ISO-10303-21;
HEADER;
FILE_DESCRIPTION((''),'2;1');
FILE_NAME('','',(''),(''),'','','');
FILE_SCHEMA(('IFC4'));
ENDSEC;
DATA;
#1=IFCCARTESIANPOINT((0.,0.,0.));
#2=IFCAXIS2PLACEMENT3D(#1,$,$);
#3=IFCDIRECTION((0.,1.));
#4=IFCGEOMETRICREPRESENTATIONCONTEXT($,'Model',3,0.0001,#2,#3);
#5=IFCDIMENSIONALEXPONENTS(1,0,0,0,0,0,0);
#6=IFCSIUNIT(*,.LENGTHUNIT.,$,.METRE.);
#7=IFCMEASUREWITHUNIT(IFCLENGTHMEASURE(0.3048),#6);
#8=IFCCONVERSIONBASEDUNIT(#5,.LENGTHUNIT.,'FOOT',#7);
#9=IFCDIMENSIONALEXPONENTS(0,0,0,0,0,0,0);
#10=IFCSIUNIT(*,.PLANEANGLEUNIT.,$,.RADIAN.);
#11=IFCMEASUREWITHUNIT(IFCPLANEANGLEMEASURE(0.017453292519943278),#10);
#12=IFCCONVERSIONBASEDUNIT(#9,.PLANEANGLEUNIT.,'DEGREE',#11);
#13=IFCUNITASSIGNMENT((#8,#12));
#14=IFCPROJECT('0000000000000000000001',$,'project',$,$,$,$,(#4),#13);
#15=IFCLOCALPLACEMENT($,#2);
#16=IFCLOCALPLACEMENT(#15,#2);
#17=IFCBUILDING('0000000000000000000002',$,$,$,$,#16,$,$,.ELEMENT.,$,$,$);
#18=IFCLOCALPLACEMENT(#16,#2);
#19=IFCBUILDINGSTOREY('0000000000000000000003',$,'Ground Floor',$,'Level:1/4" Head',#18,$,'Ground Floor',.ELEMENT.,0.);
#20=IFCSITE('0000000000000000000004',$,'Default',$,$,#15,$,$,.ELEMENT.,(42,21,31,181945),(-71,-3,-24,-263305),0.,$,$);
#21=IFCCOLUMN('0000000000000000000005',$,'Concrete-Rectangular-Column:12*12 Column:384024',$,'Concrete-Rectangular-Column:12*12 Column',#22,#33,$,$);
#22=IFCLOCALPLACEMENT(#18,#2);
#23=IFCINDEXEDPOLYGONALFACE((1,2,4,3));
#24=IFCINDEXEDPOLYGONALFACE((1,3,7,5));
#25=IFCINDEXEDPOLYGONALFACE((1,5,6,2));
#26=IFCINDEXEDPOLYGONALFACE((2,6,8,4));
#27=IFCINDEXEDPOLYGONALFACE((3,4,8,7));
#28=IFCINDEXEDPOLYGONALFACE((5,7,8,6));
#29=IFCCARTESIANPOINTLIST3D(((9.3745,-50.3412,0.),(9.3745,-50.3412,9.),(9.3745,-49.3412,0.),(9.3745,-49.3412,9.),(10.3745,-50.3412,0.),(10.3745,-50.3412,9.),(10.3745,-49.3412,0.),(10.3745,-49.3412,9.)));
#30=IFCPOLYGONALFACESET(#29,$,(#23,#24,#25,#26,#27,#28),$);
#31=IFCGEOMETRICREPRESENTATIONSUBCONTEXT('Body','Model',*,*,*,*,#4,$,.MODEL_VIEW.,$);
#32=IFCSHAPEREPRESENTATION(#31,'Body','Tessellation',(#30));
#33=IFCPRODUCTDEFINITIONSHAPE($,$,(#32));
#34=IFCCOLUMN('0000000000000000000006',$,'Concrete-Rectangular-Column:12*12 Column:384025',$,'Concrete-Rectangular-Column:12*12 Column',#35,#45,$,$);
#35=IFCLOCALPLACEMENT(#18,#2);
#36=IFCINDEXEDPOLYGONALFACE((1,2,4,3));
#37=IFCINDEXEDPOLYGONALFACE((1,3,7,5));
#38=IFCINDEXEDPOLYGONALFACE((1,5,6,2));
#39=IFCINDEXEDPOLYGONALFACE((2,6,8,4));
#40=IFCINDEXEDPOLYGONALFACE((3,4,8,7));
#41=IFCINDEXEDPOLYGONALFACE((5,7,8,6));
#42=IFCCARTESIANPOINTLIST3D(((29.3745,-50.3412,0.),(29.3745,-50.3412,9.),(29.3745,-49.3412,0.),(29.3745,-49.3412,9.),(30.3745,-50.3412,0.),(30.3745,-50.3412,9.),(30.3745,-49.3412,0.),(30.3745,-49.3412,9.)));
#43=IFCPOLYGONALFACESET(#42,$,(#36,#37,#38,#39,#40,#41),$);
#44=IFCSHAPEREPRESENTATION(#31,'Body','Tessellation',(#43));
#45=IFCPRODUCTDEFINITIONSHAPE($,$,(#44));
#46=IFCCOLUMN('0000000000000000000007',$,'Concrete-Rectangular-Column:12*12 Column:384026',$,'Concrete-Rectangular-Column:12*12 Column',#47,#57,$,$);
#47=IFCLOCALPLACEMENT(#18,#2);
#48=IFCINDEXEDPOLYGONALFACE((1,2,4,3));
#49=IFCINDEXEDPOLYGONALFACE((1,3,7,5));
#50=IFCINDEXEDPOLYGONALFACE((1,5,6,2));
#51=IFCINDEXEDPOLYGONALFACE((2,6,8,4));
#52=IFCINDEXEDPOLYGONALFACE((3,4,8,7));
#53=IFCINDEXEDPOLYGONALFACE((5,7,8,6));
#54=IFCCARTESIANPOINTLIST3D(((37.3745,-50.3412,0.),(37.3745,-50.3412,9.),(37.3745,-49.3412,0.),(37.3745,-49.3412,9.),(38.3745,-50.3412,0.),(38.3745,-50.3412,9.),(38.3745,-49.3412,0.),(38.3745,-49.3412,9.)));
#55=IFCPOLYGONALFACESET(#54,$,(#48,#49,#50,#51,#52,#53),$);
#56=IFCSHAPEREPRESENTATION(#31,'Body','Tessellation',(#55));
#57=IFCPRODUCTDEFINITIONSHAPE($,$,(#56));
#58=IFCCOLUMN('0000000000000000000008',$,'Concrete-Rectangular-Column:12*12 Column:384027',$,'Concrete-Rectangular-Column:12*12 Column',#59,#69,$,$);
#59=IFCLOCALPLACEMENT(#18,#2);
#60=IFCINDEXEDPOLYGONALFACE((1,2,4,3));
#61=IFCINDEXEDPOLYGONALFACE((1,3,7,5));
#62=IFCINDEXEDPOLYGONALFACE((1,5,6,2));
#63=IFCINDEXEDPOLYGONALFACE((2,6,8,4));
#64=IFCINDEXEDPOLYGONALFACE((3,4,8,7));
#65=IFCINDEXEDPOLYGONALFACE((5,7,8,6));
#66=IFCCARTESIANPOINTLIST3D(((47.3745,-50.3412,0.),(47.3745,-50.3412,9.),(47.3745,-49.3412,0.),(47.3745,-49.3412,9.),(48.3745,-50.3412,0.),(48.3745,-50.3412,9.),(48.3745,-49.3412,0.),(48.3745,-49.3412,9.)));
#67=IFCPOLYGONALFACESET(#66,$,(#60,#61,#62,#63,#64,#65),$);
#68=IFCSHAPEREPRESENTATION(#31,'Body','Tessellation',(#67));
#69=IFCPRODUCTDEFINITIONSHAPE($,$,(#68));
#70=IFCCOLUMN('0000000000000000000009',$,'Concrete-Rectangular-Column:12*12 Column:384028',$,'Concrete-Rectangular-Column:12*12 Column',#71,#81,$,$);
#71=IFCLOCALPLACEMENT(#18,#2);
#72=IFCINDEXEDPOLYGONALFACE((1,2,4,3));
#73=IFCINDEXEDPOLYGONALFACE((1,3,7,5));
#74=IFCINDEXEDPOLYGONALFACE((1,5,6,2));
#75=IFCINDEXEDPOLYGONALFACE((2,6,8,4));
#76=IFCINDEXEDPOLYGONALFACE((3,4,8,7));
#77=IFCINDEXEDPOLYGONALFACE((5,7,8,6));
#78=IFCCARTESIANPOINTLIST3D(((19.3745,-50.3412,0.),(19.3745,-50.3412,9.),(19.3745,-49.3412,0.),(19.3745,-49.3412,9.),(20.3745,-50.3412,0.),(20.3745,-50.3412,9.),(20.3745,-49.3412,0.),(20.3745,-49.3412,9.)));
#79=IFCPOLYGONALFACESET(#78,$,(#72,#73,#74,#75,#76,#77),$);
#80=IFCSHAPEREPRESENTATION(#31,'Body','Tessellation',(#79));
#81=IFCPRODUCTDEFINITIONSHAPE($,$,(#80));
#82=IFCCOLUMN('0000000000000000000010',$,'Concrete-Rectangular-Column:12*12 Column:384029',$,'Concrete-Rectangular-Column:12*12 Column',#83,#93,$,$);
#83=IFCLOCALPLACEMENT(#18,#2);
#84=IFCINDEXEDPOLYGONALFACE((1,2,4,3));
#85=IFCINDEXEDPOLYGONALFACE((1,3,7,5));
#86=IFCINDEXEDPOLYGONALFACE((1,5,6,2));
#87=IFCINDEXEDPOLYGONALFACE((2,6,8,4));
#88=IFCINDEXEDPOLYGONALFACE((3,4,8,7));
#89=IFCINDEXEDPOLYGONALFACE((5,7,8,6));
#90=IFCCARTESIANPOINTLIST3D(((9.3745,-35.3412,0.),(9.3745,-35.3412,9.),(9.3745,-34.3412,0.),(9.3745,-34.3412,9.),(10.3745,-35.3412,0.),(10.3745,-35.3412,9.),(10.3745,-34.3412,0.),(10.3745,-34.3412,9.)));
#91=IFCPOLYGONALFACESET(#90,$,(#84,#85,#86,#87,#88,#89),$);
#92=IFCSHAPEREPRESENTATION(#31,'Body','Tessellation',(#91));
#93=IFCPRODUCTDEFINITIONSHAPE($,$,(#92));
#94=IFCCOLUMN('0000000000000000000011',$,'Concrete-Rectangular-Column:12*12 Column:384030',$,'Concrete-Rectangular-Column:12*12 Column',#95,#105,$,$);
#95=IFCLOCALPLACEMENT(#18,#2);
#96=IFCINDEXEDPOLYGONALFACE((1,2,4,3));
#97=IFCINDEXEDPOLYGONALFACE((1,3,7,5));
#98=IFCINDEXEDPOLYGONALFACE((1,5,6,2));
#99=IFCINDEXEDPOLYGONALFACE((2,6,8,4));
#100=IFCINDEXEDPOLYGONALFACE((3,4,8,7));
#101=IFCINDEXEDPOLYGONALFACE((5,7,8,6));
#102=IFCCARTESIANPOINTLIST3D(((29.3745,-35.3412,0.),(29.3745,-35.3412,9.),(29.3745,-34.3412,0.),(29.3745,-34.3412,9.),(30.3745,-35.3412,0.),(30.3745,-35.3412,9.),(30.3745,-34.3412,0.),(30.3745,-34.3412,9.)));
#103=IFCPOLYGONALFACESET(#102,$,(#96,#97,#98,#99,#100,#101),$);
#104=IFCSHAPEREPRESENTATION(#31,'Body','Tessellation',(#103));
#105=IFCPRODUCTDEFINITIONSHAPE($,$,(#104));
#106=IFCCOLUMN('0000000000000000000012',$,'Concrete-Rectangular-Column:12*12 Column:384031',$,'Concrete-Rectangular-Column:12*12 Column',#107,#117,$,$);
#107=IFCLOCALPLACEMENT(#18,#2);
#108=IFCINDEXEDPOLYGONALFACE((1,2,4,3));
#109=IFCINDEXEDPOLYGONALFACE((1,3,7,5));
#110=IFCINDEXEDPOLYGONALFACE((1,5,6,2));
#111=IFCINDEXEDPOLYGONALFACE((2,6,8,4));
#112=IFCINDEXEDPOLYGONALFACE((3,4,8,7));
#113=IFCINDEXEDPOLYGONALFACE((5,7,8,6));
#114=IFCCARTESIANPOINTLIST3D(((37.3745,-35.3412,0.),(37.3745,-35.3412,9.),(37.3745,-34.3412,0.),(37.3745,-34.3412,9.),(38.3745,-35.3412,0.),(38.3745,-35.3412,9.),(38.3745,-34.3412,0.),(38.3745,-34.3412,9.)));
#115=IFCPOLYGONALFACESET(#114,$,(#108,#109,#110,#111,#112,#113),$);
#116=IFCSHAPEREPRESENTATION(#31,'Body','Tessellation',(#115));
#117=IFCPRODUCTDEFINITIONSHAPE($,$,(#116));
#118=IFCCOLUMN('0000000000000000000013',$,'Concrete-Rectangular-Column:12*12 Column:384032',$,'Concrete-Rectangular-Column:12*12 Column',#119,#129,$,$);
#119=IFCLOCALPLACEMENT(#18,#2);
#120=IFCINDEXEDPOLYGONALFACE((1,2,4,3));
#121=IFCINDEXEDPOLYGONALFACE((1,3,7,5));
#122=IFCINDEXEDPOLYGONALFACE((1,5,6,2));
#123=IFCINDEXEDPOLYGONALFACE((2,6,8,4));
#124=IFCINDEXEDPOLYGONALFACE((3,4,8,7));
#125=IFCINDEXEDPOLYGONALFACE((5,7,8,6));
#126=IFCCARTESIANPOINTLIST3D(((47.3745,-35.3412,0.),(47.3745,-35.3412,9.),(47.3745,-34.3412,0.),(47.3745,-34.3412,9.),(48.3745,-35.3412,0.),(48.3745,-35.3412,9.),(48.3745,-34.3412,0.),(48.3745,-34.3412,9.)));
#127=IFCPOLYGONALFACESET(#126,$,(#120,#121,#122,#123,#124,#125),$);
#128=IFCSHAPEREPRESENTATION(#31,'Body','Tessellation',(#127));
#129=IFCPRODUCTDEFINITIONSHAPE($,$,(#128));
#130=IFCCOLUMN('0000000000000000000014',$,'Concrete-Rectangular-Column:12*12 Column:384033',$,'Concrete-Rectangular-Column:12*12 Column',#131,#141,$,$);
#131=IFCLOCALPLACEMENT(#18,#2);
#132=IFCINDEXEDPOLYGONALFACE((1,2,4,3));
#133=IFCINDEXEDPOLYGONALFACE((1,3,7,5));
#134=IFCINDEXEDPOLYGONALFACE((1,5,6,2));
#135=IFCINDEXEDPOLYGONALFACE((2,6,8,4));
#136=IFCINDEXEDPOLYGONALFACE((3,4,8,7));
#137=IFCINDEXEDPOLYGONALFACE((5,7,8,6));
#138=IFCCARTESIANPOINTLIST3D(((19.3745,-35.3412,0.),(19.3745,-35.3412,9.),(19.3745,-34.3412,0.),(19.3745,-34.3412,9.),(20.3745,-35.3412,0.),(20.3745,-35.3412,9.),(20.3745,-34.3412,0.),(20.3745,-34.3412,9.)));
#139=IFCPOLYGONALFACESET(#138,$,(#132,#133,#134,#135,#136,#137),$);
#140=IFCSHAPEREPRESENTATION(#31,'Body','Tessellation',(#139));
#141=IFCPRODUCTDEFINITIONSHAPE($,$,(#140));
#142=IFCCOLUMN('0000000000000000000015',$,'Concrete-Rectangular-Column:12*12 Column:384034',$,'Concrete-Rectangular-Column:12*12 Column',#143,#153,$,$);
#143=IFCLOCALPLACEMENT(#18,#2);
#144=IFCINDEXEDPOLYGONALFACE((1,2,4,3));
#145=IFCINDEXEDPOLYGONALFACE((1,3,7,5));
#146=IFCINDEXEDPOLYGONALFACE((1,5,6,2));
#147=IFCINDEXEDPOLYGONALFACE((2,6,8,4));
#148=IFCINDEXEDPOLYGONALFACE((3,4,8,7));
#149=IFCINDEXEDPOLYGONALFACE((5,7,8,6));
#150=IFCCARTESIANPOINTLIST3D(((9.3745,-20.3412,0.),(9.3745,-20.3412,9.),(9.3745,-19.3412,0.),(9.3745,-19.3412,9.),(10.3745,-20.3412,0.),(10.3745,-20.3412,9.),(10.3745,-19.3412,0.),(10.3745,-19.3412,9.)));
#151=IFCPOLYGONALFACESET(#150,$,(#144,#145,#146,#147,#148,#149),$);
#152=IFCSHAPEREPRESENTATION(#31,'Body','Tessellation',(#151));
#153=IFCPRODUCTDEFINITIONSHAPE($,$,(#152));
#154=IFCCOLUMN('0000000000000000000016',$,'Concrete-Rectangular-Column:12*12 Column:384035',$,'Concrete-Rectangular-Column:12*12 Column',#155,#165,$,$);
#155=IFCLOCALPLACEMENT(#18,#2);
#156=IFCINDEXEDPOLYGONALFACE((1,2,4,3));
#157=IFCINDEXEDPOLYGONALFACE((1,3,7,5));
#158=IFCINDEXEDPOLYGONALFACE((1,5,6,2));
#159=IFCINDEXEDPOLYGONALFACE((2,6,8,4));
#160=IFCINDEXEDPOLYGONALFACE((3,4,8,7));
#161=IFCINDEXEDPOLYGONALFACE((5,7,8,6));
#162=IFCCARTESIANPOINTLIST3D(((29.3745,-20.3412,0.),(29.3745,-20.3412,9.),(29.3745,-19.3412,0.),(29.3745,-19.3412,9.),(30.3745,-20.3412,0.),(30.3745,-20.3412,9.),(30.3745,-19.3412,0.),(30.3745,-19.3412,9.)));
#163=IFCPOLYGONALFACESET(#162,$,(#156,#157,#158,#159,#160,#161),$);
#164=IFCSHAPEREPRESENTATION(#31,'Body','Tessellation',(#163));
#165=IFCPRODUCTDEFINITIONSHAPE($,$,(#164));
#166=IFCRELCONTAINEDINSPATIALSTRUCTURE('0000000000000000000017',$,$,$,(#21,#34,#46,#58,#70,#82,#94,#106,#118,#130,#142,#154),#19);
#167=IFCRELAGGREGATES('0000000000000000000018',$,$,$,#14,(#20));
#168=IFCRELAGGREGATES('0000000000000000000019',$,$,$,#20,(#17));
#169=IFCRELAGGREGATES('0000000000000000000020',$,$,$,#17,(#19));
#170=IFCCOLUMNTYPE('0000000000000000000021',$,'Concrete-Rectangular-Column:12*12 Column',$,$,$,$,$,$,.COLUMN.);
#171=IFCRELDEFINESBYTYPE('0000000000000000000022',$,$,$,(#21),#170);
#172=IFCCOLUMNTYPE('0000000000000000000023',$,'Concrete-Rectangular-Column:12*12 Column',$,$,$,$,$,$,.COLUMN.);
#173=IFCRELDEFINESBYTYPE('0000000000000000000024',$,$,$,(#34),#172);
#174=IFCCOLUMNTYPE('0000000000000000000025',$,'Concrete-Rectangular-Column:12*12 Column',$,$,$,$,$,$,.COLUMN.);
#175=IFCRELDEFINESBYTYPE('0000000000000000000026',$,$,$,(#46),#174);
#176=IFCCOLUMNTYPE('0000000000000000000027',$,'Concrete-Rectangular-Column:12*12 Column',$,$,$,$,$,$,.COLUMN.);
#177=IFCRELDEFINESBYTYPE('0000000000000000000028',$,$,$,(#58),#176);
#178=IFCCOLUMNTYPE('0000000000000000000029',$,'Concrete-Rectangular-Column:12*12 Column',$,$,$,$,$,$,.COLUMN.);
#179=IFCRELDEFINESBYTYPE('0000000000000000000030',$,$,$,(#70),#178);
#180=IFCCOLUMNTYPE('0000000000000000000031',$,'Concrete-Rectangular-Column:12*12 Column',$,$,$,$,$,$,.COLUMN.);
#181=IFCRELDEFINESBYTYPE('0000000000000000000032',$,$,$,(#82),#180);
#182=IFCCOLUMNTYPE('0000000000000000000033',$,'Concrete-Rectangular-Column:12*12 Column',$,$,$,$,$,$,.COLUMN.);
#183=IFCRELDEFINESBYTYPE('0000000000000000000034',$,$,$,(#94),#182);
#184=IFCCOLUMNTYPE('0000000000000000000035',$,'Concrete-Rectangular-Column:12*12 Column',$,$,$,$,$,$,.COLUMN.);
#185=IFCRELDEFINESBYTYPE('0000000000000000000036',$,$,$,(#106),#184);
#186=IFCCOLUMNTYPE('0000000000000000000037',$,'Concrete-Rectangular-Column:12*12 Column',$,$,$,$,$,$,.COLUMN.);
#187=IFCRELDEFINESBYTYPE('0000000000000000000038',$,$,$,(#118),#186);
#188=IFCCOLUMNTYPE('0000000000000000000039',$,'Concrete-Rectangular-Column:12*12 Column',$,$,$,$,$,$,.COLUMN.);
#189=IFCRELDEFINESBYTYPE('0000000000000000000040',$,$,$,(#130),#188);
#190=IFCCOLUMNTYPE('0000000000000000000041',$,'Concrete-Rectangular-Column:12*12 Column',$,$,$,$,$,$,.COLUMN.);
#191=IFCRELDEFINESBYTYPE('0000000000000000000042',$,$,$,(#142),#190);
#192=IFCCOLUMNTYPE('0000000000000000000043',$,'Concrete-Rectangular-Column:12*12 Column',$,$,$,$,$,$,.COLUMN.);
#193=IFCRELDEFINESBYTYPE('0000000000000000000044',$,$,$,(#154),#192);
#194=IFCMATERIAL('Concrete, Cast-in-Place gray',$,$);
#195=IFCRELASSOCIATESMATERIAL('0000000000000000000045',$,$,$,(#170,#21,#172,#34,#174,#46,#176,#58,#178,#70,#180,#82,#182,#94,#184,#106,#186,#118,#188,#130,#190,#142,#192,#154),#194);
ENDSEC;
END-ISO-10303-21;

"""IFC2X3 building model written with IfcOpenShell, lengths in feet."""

from ifc_helpers import new_model, entity, si_unit, converted_unit, direction, frame, frame_2d, origin, origin_2d_with_axis, place, context, subcontext, project, spatial, rectangle, extrude, source, transform, mapped, material, type_object, type_shapes, element, save


model = new_model("IFC2X3")

# Units and contexts
model_context = context("Model", 3, precision=0.0001, world=origin(), true_north=direction((0.0, 1.0)))
body_context = subcontext(model_context, "Body", "Model", "MODEL_VIEW")
ifc_project = project(units=[converted_unit("LENGTHUNIT", "FOOT", entity("IfcLengthMeasure", 0.3048), si_unit("LENGTHUNIT", "METRE"), dimensions=[1, 0, 0, 0, 0, 0, 0]), converted_unit("PLANEANGLEUNIT", "DEGREE", entity("IfcPlaneAngleMeasure", 0.017453292519943278), si_unit("PLANEANGLEUNIT", "RADIAN"), dimensions=[0, 0, 0, 0, 0, 0, 0])], contexts=[model_context])

# Site, building, storey
site_placement = place(None, origin())
site = spatial("IfcSite", under=ifc_project, at=site_placement, Name="Default", CompositionType="ELEMENT", RefLatitude=(42, 21, 31, 181945), RefLongitude=(-71, -3, -24, -263305), RefElevation=0.0)
building_placement = place(site_placement, origin())
building = spatial("IfcBuilding", under=site, at=building_placement, CompositionType="ELEMENT")
storey_placement = place(building_placement, origin())
storey = spatial("IfcBuildingStorey", under=building, at=storey_placement, Name="Ground Floor", ObjectType="Level:1/4\" Head", LongName="Ground Floor", CompositionType="ELEMENT", Elevation=0.0)

# Columns
ifc_material = material(Name="Concrete, Cast-in-Place gray")
column_type_1 = type_object("IfcColumnType", Name="Concrete-Rectangular-Column:12*12 Column", PredefinedType="COLUMN", material=ifc_material)
shared_shape_1 = source(origin(), body_context, "Body", "SweptSolid", [
    extrude(rectangle(XDim=1.0, YDim=1.0, at=origin_2d_with_axis()), frame((9.8745, -49.8412, 0.0), z_axis=(0.0, 0.0, 1.0), x_axis=(-1.0, 0.0, 0.0)), (0.0, 0.0, 1.0), 9.0),
])
type_shapes(column_type_1, [shared_shape_1])
column_1_placement = place(storey_placement, origin())
element("IfcColumn", 1, at=column_1_placement, inside=storey, type_object=column_type_1, material=ifc_material, Name="Concrete-Rectangular-Column:12*12 Column:384024", ObjectType="Concrete-Rectangular-Column:12*12 Column", context=body_context, shape_type="MappedRepresentation", body=[
    mapped(shared_shape_1, transform((0.0, 0.0, 0.0), scale=1.0)),
])
column_type_2 = type_object("IfcColumnType", Name="Concrete-Rectangular-Column:12*12 Column", PredefinedType="COLUMN", material=ifc_material)
shared_shape_2 = source(origin(), body_context, "Body", "SweptSolid", [
    extrude(rectangle(XDim=1.0, YDim=1.0, at=frame_2d((0.0, 0.0), x_axis=(1.0, 0.0))), frame((29.8745, -49.8412, 0.0), z_axis=(0.0, 0.0, 1.0), x_axis=(-1.0, 0.0, 0.0)), (0.0, 0.0, 1.0), 9.0),
])
type_shapes(column_type_2, [shared_shape_2])
column_2_placement = place(storey_placement, origin())
element("IfcColumn", 2, at=column_2_placement, inside=storey, type_object=column_type_2, material=ifc_material, Name="Concrete-Rectangular-Column:12*12 Column:384025", ObjectType="Concrete-Rectangular-Column:12*12 Column", context=body_context, shape_type="MappedRepresentation", body=[
    mapped(shared_shape_2, transform((0.0, 0.0, 0.0), scale=1.0)),
])
column_type_3 = type_object("IfcColumnType", Name="Concrete-Rectangular-Column:12*12 Column", PredefinedType="COLUMN", material=ifc_material)
shared_shape_3 = source(origin(), body_context, "Body", "SweptSolid", [
    extrude(rectangle(XDim=1.0, YDim=1.0, at=origin_2d_with_axis()), frame((37.8745, -49.8412, 0.0), z_axis=(0.0, 0.0, 1.0), x_axis=(-1.0, 0.0, 0.0)), (0.0, 0.0, 1.0), 9.0),
])
type_shapes(column_type_3, [shared_shape_3])
column_3_placement = place(storey_placement, origin())
element("IfcColumn", 3, at=column_3_placement, inside=storey, type_object=column_type_3, material=ifc_material, Name="Concrete-Rectangular-Column:12*12 Column:384026", ObjectType="Concrete-Rectangular-Column:12*12 Column", context=body_context, shape_type="MappedRepresentation", body=[
    mapped(shared_shape_3, transform((0.0, 0.0, 0.0), scale=1.0)),
])
column_type_4 = type_object("IfcColumnType", Name="Concrete-Rectangular-Column:12*12 Column", PredefinedType="COLUMN", material=ifc_material)
shared_shape_4 = source(origin(), body_context, "Body", "SweptSolid", [
    extrude(rectangle(XDim=1.0, YDim=1.0, at=origin_2d_with_axis()), frame((47.8745, -49.8412, 0.0), z_axis=(0.0, 0.0, 1.0), x_axis=(-1.0, 0.0, 0.0)), (0.0, 0.0, 1.0), 9.0),
])
type_shapes(column_type_4, [shared_shape_4])
column_4_placement = place(storey_placement, origin())
element("IfcColumn", 4, at=column_4_placement, inside=storey, type_object=column_type_4, material=ifc_material, Name="Concrete-Rectangular-Column:12*12 Column:384027", ObjectType="Concrete-Rectangular-Column:12*12 Column", context=body_context, shape_type="MappedRepresentation", body=[
    mapped(shared_shape_4, transform((0.0, 0.0, 0.0), scale=1.0)),
])
column_type_5 = type_object("IfcColumnType", Name="Concrete-Rectangular-Column:12*12 Column", PredefinedType="COLUMN", material=ifc_material)
shared_shape_5 = source(origin(), body_context, "Body", "SweptSolid", [
    extrude(rectangle(XDim=1.0, YDim=1.0, at=frame_2d((0.0, 0.0), x_axis=(1.0, 0.0))), frame((19.8745, -49.8412, 0.0), z_axis=(0.0, 0.0, 1.0), x_axis=(-1.0, 0.0, 0.0)), (0.0, 0.0, 1.0), 9.0),
])
type_shapes(column_type_5, [shared_shape_5])
column_5_placement = place(storey_placement, origin())
element("IfcColumn", 5, at=column_5_placement, inside=storey, type_object=column_type_5, material=ifc_material, Name="Concrete-Rectangular-Column:12*12 Column:384028", ObjectType="Concrete-Rectangular-Column:12*12 Column", context=body_context, shape_type="MappedRepresentation", body=[
    mapped(shared_shape_5, transform((0.0, 0.0, 0.0), scale=1.0)),
])
column_type_6 = type_object("IfcColumnType", Name="Concrete-Rectangular-Column:12*12 Column", PredefinedType="COLUMN", material=ifc_material)
shared_shape_6 = source(origin(), body_context, "Body", "SweptSolid", [
    extrude(rectangle(XDim=1.0, YDim=1.0, at=origin_2d_with_axis()), frame((9.8745, -34.8412, 0.0), z_axis=(0.0, 0.0, 1.0), x_axis=(-1.0, 0.0, 0.0)), (0.0, 0.0, 1.0), 9.0),
])
type_shapes(column_type_6, [shared_shape_6])
column_6_placement = place(storey_placement, origin())
element("IfcColumn", 6, at=column_6_placement, inside=storey, type_object=column_type_6, material=ifc_material, Name="Concrete-Rectangular-Column:12*12 Column:384029", ObjectType="Concrete-Rectangular-Column:12*12 Column", context=body_context, shape_type="MappedRepresentation", body=[
    mapped(shared_shape_6, transform((0.0, 0.0, 0.0), scale=1.0)),
])
column_type_7 = type_object("IfcColumnType", Name="Concrete-Rectangular-Column:12*12 Column", PredefinedType="COLUMN", material=ifc_material)
shared_shape_7 = source(origin(), body_context, "Body", "SweptSolid", [
    extrude(rectangle(XDim=1.0, YDim=1.0, at=frame_2d((0.0, 0.0), x_axis=(1.0, 0.0))), frame((29.8745, -34.8412, 0.0), z_axis=(0.0, 0.0, 1.0), x_axis=(-1.0, 0.0, 0.0)), (0.0, 0.0, 1.0), 9.0),
])
type_shapes(column_type_7, [shared_shape_7])
column_7_placement = place(storey_placement, origin())
element("IfcColumn", 7, at=column_7_placement, inside=storey, type_object=column_type_7, material=ifc_material, Name="Concrete-Rectangular-Column:12*12 Column:384030", ObjectType="Concrete-Rectangular-Column:12*12 Column", context=body_context, shape_type="MappedRepresentation", body=[
    mapped(shared_shape_7, transform((0.0, 0.0, 0.0), scale=1.0)),
])
column_type_8 = type_object("IfcColumnType", Name="Concrete-Rectangular-Column:12*12 Column", PredefinedType="COLUMN", material=ifc_material)
shared_shape_8 = source(origin(), body_context, "Body", "SweptSolid", [
    extrude(rectangle(XDim=1.0, YDim=1.0, at=origin_2d_with_axis()), frame((37.8745, -34.8412, 0.0), z_axis=(0.0, 0.0, 1.0), x_axis=(-1.0, 0.0, 0.0)), (0.0, 0.0, 1.0), 9.0),
])
type_shapes(column_type_8, [shared_shape_8])
column_8_placement = place(storey_placement, origin())
element("IfcColumn", 8, at=column_8_placement, inside=storey, type_object=column_type_8, material=ifc_material, Name="Concrete-Rectangular-Column:12*12 Column:384031", ObjectType="Concrete-Rectangular-Column:12*12 Column", context=body_context, shape_type="MappedRepresentation", body=[
    mapped(shared_shape_8, transform((0.0, 0.0, 0.0), scale=1.0)),
])
column_type_9 = type_object("IfcColumnType", Name="Concrete-Rectangular-Column:12*12 Column", PredefinedType="COLUMN", material=ifc_material)
shared_shape_9 = source(origin(), body_context, "Body", "SweptSolid", [
    extrude(rectangle(XDim=1.0, YDim=1.0, at=origin_2d_with_axis()), frame((47.8745, -34.8412, 0.0), z_axis=(0.0, 0.0, 1.0), x_axis=(-1.0, 0.0, 0.0)), (0.0, 0.0, 1.0), 9.0),
])
type_shapes(column_type_9, [shared_shape_9])
column_9_placement = place(storey_placement, origin())
element("IfcColumn", 9, at=column_9_placement, inside=storey, type_object=column_type_9, material=ifc_material, Name="Concrete-Rectangular-Column:12*12 Column:384032", ObjectType="Concrete-Rectangular-Column:12*12 Column", context=body_context, shape_type="MappedRepresentation", body=[
    mapped(shared_shape_9, transform((0.0, 0.0, 0.0), scale=1.0)),
])
column_type_10 = type_object("IfcColumnType", Name="Concrete-Rectangular-Column:12*12 Column", PredefinedType="COLUMN", material=ifc_material)
shared_shape_10 = source(origin(), body_context, "Body", "SweptSolid", [
    extrude(rectangle(XDim=1.0, YDim=1.0, at=frame_2d((0.0, 0.0), x_axis=(1.0, 0.0))), frame((19.8745, -34.8412, 0.0), z_axis=(0.0, 0.0, 1.0), x_axis=(-1.0, 0.0, 0.0)), (0.0, 0.0, 1.0), 9.0),
])
type_shapes(column_type_10, [shared_shape_10])
column_10_placement = place(storey_placement, origin())
element("IfcColumn", 10, at=column_10_placement, inside=storey, type_object=column_type_10, material=ifc_material, Name="Concrete-Rectangular-Column:12*12 Column:384033", ObjectType="Concrete-Rectangular-Column:12*12 Column", context=body_context, shape_type="MappedRepresentation", body=[
    mapped(shared_shape_10, transform((0.0, 0.0, 0.0), scale=1.0)),
])
column_type_11 = type_object("IfcColumnType", Name="Concrete-Rectangular-Column:12*12 Column", PredefinedType="COLUMN", material=ifc_material)
shared_shape_11 = source(origin(), body_context, "Body", "SweptSolid", [
    extrude(rectangle(XDim=1.0, YDim=1.0, at=frame_2d((0.0, 0.0), x_axis=(1.0, 0.0))), frame((9.8745, -19.8412, 0.0), z_axis=(0.0, 0.0, 1.0), x_axis=(-1.0, 0.0, 0.0)), (0.0, 0.0, 1.0), 9.0),
])
type_shapes(column_type_11, [shared_shape_11])
column_11_placement = place(storey_placement, origin())
element("IfcColumn", 11, at=column_11_placement, inside=storey, type_object=column_type_11, material=ifc_material, Name="Concrete-Rectangular-Column:12*12 Column:384034", ObjectType="Concrete-Rectangular-Column:12*12 Column", context=body_context, shape_type="MappedRepresentation", body=[
    mapped(shared_shape_11, transform((0.0, 0.0, 0.0), scale=1.0)),
])
column_type_12 = type_object("IfcColumnType", Name="Concrete-Rectangular-Column:12*12 Column", PredefinedType="COLUMN", material=ifc_material)
shared_shape_12 = source(origin(), body_context, "Body", "SweptSolid", [
    extrude(rectangle(XDim=1.0, YDim=1.0, at=frame_2d((0.0, 0.0), x_axis=(1.0, 0.0))), frame((29.8745, -19.8412, 0.0), z_axis=(0.0, 0.0, 1.0), x_axis=(-1.0, 0.0, 0.0)), (0.0, 0.0, 1.0), 9.0),
])
type_shapes(column_type_12, [shared_shape_12])
column_12_placement = place(storey_placement, origin())
element("IfcColumn", 12, at=column_12_placement, inside=storey, type_object=column_type_12, material=ifc_material, Name="Concrete-Rectangular-Column:12*12 Column:384035", ObjectType="Concrete-Rectangular-Column:12*12 Column", context=body_context, shape_type="MappedRepresentation", body=[
    mapped(shared_shape_12, transform((0.0, 0.0, 0.0), scale=1.0)),
])

save(model, "model.ifc")
